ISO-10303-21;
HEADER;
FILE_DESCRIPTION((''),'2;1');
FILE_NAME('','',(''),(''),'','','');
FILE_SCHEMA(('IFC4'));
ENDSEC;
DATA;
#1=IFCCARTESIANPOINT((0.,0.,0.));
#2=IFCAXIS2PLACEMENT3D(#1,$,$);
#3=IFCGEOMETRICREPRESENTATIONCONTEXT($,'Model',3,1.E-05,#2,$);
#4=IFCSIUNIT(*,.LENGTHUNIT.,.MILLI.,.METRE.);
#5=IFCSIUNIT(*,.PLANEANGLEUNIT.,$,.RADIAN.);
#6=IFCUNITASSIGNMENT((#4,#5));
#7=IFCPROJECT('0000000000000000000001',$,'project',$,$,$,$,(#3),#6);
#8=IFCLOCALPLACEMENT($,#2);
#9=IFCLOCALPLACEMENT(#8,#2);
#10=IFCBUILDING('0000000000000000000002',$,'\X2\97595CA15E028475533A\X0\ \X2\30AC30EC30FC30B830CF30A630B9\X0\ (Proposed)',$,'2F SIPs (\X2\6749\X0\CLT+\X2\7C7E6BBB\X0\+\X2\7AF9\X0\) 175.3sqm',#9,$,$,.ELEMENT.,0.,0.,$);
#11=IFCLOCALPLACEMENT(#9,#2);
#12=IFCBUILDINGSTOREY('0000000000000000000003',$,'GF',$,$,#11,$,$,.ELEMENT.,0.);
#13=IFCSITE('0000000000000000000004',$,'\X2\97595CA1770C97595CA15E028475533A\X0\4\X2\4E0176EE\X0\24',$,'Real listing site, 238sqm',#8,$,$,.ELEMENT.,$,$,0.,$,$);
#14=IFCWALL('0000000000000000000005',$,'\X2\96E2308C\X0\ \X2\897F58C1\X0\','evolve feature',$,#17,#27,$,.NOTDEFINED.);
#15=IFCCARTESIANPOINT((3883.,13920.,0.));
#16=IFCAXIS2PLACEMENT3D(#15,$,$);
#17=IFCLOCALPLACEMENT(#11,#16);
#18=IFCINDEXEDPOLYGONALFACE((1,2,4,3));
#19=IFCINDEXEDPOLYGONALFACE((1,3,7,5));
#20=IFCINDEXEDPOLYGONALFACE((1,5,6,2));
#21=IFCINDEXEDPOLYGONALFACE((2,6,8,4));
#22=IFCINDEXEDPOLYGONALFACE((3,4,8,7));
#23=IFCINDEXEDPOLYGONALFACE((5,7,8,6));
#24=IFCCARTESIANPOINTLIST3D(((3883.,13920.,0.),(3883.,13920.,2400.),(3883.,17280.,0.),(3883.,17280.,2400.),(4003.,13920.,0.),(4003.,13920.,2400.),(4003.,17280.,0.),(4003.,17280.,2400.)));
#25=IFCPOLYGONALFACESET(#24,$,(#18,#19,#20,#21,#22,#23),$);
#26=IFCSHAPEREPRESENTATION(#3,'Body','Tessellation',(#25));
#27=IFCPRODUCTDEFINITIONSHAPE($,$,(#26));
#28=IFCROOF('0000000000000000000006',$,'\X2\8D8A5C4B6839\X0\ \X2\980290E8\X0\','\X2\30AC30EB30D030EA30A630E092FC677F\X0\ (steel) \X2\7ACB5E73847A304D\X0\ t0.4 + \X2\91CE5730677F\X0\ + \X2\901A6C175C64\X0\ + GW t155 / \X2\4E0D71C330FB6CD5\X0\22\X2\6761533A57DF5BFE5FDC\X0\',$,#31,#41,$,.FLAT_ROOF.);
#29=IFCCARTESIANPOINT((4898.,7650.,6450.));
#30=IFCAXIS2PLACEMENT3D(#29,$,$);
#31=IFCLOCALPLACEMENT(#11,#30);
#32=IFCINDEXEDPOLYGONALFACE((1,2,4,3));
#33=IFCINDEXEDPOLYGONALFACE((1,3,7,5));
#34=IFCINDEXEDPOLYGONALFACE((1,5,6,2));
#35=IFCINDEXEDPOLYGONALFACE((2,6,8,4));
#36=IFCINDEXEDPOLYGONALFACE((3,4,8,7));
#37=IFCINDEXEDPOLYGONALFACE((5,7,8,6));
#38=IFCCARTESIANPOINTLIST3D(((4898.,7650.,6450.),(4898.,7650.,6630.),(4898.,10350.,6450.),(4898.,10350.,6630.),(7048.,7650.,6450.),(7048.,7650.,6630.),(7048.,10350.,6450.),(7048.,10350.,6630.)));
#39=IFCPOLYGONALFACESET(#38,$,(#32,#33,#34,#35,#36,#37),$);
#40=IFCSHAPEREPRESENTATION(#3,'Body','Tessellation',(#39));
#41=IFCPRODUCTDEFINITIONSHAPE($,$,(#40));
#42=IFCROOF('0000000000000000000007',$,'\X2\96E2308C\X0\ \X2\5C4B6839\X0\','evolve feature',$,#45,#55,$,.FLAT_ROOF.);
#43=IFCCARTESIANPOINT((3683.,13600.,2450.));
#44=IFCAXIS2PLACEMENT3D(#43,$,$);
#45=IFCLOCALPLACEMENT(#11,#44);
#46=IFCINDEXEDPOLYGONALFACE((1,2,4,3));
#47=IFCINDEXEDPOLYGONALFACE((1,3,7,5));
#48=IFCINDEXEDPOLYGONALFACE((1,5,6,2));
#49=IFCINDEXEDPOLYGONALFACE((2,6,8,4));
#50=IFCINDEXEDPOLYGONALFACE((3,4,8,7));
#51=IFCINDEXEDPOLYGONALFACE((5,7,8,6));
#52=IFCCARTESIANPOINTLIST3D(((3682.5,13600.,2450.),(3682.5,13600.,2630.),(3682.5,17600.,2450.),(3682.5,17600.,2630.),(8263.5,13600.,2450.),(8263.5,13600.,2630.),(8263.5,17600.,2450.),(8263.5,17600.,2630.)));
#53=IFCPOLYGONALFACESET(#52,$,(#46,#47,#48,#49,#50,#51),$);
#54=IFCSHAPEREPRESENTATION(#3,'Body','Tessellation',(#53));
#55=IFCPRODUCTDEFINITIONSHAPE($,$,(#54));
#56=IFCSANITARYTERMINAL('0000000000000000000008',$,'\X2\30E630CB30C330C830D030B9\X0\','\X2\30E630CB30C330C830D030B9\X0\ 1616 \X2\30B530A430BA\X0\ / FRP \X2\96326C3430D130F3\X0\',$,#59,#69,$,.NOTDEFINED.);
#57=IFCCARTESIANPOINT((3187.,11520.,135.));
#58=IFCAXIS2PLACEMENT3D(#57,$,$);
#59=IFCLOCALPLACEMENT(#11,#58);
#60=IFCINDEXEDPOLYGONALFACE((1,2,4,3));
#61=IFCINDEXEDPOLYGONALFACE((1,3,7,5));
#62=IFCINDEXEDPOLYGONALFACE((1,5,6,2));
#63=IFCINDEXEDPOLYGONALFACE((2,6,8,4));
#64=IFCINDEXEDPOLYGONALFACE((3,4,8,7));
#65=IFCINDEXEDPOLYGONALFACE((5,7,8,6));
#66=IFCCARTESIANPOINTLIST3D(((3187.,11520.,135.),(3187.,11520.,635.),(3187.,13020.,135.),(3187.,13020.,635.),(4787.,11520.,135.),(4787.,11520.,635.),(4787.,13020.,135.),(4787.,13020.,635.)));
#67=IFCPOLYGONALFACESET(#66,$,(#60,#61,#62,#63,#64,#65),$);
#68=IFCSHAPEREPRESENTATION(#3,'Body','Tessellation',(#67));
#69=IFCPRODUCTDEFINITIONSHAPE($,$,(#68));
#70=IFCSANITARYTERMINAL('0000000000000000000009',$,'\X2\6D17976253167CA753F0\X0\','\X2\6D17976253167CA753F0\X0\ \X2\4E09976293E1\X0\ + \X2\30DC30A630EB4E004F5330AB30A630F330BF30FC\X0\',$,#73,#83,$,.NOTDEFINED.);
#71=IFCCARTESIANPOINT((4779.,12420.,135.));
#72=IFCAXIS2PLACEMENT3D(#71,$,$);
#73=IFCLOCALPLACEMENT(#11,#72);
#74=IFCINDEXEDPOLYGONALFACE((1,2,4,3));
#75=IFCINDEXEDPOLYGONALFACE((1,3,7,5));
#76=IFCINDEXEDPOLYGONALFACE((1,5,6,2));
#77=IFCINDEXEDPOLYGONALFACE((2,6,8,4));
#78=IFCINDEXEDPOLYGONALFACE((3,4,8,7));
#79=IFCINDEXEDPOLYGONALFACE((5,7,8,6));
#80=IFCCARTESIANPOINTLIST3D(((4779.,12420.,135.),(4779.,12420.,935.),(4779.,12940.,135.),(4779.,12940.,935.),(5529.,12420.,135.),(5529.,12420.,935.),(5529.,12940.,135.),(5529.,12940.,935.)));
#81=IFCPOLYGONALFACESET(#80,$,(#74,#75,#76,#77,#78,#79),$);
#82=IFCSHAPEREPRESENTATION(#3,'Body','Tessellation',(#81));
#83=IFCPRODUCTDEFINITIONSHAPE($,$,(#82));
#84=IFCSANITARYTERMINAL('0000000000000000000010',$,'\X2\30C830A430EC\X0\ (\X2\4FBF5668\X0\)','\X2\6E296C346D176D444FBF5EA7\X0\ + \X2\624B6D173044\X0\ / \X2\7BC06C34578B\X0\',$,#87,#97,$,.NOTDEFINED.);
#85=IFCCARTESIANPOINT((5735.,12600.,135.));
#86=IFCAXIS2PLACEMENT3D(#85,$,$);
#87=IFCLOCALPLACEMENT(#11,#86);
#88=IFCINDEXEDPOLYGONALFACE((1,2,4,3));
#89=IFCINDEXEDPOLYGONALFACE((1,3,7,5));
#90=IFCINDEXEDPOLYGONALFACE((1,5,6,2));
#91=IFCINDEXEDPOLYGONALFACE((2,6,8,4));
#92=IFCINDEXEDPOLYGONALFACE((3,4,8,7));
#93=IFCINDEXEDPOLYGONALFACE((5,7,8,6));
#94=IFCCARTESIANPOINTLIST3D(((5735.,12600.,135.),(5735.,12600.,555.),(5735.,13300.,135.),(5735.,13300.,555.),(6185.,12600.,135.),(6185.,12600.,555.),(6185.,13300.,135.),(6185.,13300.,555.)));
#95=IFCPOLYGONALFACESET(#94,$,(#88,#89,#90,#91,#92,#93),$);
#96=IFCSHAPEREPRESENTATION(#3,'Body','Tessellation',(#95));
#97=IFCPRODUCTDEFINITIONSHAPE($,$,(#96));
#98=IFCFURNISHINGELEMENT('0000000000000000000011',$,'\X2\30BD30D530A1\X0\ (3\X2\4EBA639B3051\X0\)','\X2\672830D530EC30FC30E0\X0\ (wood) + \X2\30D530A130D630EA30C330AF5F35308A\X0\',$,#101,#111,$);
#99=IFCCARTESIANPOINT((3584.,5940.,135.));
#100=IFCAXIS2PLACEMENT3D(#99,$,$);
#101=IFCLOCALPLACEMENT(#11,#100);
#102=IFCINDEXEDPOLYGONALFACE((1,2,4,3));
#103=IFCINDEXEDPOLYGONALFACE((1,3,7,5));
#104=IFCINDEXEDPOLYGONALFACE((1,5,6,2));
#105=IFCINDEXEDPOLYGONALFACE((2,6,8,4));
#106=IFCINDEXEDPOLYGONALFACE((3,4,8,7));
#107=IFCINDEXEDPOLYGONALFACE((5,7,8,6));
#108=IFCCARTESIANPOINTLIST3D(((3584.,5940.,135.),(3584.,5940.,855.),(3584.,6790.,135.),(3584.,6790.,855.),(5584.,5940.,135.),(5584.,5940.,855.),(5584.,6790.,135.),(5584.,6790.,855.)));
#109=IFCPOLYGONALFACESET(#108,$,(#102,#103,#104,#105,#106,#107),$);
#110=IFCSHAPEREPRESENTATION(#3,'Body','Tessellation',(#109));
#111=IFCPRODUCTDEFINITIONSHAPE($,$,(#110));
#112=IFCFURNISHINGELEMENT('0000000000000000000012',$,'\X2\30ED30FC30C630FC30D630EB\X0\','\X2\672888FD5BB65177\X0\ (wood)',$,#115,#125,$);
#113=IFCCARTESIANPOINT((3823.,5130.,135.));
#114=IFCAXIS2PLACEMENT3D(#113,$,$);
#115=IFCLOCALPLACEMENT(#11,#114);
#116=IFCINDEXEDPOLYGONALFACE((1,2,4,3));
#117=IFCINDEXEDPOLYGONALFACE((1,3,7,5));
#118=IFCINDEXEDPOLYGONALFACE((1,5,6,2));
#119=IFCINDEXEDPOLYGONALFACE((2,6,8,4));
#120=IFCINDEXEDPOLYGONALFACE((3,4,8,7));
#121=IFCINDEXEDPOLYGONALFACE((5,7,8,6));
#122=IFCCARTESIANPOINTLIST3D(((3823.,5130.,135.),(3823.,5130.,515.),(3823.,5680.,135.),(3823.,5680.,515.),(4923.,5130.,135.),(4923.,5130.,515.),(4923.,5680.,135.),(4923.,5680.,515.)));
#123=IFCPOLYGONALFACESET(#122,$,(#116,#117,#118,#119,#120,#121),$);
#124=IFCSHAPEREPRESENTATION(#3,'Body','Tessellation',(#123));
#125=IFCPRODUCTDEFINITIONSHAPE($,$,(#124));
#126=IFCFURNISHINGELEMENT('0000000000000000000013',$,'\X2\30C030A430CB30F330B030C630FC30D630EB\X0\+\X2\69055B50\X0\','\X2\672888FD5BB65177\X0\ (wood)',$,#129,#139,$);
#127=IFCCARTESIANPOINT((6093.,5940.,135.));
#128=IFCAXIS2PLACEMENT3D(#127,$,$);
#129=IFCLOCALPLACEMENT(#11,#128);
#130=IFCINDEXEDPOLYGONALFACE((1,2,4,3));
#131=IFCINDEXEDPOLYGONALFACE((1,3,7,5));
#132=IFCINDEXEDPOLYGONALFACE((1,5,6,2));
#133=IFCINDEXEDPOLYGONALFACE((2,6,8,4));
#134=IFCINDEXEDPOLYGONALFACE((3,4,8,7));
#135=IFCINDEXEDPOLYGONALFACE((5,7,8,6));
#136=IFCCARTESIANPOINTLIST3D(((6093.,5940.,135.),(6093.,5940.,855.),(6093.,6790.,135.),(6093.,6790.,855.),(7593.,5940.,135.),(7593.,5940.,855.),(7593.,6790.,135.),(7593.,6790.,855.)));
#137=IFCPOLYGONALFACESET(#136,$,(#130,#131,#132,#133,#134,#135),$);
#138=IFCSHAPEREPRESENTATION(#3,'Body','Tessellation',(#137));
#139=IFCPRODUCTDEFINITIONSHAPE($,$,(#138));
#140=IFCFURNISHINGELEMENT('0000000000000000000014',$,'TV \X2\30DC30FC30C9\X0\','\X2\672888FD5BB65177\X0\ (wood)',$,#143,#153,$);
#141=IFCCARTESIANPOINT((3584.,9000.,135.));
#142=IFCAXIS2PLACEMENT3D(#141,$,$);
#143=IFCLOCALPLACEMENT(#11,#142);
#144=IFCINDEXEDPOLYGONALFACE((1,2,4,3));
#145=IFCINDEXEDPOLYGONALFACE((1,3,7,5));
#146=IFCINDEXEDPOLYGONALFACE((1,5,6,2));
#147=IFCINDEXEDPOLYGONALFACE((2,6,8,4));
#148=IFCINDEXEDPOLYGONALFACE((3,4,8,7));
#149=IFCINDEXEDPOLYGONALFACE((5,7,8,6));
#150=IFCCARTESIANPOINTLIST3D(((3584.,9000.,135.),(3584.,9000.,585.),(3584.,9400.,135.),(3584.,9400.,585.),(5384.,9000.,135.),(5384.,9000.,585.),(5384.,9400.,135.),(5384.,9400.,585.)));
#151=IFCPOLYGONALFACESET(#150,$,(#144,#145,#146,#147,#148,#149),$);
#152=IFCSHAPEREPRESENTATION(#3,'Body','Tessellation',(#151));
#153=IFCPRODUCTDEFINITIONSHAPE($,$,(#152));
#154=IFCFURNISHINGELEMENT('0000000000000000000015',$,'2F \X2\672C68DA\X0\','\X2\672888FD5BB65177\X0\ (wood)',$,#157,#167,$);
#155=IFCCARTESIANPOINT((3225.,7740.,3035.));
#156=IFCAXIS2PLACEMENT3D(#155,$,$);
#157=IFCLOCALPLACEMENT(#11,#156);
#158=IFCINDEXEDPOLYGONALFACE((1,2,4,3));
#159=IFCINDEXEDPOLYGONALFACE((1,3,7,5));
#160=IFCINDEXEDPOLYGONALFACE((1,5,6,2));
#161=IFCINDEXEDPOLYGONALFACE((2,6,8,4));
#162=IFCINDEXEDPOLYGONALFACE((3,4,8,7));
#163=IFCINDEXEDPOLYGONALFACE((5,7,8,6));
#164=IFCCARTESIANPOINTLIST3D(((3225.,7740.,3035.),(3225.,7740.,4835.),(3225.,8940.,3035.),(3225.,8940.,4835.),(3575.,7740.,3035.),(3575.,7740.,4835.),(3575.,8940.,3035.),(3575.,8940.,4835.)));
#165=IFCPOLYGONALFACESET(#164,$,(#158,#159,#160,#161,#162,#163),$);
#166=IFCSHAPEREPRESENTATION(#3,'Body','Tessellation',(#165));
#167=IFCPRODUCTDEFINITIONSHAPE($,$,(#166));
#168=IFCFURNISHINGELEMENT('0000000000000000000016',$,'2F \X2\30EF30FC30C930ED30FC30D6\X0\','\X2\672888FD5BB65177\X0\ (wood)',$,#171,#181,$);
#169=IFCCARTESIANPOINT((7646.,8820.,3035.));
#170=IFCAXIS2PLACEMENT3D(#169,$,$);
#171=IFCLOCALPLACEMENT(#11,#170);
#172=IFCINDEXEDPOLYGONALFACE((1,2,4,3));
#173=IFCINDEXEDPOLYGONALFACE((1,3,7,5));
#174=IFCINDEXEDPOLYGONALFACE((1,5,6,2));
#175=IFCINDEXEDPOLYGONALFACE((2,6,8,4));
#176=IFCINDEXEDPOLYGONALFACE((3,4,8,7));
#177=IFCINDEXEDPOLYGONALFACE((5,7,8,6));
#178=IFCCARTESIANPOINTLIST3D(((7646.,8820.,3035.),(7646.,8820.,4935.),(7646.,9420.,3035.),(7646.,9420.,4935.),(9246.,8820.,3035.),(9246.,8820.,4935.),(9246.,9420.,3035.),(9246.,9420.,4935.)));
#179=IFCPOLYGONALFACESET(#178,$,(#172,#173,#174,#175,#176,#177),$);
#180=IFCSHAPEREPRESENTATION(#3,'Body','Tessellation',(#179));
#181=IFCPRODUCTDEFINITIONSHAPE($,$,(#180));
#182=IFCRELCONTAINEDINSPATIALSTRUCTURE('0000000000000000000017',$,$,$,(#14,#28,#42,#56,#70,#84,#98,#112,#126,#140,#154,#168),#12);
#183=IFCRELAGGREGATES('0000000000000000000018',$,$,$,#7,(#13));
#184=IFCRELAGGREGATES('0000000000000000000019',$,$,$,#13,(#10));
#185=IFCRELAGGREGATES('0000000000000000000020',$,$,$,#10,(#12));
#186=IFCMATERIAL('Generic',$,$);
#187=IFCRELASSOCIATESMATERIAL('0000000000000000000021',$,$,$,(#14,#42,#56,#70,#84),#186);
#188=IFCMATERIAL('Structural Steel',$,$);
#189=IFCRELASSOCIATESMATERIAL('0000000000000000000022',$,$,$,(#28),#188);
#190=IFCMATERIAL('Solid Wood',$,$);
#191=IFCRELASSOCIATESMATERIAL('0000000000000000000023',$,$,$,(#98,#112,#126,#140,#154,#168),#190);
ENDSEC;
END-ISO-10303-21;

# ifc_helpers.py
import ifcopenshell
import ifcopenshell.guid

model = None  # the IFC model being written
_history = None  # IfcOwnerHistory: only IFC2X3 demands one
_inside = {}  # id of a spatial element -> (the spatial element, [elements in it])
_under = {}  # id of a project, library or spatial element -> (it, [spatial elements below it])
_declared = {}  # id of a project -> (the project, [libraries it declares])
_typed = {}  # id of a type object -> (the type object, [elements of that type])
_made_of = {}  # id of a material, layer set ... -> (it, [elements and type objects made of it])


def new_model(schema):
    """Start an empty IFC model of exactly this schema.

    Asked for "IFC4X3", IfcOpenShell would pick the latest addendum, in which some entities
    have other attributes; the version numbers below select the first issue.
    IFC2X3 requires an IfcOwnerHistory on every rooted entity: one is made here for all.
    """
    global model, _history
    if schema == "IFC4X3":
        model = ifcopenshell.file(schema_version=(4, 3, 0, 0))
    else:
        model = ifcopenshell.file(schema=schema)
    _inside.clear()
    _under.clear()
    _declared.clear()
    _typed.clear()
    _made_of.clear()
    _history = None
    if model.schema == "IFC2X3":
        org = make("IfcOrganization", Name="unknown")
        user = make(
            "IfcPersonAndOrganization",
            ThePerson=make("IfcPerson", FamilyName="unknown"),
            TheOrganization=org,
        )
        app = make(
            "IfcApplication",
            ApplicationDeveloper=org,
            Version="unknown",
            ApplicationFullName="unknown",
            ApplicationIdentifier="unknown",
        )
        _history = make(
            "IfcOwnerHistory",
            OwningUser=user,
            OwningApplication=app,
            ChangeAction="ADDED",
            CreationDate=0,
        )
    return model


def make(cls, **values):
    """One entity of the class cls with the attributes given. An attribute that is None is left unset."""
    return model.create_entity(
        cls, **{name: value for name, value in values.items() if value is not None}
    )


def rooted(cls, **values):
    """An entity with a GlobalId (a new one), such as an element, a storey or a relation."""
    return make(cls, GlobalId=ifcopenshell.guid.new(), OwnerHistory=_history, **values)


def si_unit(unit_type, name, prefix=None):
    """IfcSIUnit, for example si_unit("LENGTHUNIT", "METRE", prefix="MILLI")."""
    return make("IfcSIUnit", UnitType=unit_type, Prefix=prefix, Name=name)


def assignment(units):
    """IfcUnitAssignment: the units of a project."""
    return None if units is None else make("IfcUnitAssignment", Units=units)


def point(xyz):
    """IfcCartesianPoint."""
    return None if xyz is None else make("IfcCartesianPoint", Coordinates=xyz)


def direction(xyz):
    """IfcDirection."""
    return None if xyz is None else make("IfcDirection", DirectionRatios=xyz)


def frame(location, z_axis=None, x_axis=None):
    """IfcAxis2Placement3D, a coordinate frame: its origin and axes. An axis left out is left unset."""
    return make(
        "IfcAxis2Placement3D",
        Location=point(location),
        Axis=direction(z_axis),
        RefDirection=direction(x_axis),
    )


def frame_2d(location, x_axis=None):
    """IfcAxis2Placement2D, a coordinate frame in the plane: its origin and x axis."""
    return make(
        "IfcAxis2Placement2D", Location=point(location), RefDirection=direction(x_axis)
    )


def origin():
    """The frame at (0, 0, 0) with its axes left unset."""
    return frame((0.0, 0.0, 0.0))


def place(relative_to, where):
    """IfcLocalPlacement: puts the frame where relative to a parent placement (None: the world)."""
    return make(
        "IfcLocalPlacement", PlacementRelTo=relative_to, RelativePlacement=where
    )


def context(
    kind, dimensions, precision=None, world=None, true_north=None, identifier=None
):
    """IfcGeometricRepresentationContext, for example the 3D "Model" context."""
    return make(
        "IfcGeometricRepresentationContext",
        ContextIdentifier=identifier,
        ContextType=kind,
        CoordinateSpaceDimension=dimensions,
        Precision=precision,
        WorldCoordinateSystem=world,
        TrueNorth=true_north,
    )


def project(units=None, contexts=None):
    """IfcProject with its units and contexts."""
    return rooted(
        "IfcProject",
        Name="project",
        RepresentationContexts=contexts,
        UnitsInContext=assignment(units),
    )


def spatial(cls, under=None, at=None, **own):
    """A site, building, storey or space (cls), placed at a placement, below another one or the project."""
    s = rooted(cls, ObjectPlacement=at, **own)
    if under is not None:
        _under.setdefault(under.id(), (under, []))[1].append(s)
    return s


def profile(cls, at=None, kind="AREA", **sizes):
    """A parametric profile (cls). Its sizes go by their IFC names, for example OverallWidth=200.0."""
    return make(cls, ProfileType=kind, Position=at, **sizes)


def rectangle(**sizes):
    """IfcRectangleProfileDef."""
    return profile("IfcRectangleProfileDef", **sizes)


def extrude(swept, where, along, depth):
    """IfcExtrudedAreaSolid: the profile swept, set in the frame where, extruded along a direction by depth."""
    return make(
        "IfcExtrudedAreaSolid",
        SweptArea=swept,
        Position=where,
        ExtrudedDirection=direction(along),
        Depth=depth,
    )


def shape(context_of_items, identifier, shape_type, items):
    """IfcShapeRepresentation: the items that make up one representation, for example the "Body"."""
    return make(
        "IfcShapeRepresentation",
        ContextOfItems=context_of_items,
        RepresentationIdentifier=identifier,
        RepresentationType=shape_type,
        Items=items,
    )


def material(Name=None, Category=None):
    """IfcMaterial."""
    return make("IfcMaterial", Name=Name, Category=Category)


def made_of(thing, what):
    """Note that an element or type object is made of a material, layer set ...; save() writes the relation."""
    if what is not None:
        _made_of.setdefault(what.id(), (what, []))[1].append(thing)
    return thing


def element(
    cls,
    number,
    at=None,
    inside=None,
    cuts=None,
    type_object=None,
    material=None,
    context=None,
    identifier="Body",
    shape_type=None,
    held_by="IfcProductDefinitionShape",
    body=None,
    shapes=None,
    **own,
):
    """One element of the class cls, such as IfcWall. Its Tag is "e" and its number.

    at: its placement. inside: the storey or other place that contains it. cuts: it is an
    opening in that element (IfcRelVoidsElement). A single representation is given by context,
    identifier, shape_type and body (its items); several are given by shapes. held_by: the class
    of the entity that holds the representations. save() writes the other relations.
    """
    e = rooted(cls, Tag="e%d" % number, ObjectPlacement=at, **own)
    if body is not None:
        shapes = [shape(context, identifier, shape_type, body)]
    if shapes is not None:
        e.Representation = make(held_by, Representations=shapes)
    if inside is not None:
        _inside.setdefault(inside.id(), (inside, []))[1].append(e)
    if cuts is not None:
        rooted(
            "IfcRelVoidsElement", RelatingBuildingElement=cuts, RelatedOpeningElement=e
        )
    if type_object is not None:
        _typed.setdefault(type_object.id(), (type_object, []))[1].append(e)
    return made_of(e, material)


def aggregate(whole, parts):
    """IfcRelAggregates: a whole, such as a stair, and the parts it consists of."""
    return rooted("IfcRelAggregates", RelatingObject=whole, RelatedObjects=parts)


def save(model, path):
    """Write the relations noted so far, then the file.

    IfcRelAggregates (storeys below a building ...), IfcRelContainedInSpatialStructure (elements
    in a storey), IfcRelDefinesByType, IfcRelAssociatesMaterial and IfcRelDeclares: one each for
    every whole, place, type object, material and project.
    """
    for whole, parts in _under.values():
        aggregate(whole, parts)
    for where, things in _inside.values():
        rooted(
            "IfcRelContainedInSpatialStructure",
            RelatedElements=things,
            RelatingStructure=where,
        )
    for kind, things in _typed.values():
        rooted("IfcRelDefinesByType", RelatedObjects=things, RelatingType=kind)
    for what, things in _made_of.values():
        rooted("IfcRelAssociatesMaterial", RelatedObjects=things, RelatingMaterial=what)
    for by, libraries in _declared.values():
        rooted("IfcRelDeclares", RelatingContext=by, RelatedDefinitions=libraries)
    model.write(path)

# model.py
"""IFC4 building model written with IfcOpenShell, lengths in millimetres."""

from ifc_helpers import new_model, si_unit, frame, frame_2d, origin, place, context, project, spatial, rectangle, extrude, material, element, save


model = new_model("IFC4")

# Units and contexts
model_context = context("Model", 3, precision=1e-05, world=origin())
ifc_project = project(units=[si_unit("LENGTHUNIT", "METRE", prefix="MILLI"), si_unit("PLANEANGLEUNIT", "RADIAN")], contexts=[model_context])

# Site, building, storey
site_placement = place(None, origin())
site = spatial("IfcSite", under=ifc_project, at=site_placement, Name="静岡県静岡市葵区4丁目24", ObjectType="Real listing site, 238sqm", CompositionType="ELEMENT", RefElevation=0.0)
building_placement = place(site_placement, origin())
building = spatial("IfcBuilding", under=site, at=building_placement, Name="静岡市葵区 ガレージハウス (Proposed)", ObjectType="2F SIPs (杉CLT+籾殻+竹) 175.3sqm", CompositionType="ELEMENT", ElevationOfRefHeight=0.0, ElevationOfTerrain=0.0)
storey_placement = place(building_placement, origin())
storey = spatial("IfcBuildingStorey", under=building, at=storey_placement, Name="GF", CompositionType="ELEMENT", Elevation=0.0)

# Shared definitions
ifc_material_1 = material(Name="Generic")

# Shared definitions
ifc_material_2 = material(Name="Solid Wood")

# Wall
wall_1_placement = place(storey_placement, frame((3883.0, 13920.0, 0.0)))
element("IfcWall", 1, at=wall_1_placement, inside=storey, material=ifc_material_1, Name="離れ 西壁", Description="evolve feature", PredefinedType="NOTDEFINED", context=model_context, shape_type="SweptSolid", body=[
    extrude(rectangle(XDim=120.0, YDim=3360.0, at=frame_2d((60.0, 1680.0))), frame((3883.0, 13920.0, 0.0)), (0.0, 0.0, 1.0), 2400.0),
])

# Roofs
ifc_material_3 = material(Name="Structural Steel")
roof_1_placement = place(storey_placement, frame((4898.0, 7650.0, 6450.0)))
element("IfcRoof", 2, at=roof_1_placement, inside=storey, material=ifc_material_3, Name="越屋根 頂部", Description="ガルバリウム鋼板 (steel) 立平葺き t0.4 + 野地板 + 通気層 + GW t155 / 不燃・法22条区域対応", PredefinedType="FLAT_ROOF", context=model_context, shape_type="SweptSolid", body=[
    extrude(rectangle(XDim=2150.0, YDim=2700.0, at=frame_2d((1075.0, 1350.0))), frame((4898.0, 7650.0, 6450.0)), (0.0, 0.0, 1.0), 180.0),
])
roof_2_placement = place(storey_placement, frame((3683.0, 13600.0, 2450.0)))
element("IfcRoof", 3, at=roof_2_placement, inside=storey, material=ifc_material_1, Name="離れ 屋根", Description="evolve feature", PredefinedType="FLAT_ROOF", context=model_context, shape_type="SweptSolid", body=[
    extrude(rectangle(XDim=4581.0, YDim=4000.0, at=frame_2d((2290.0, 2000.0))), frame((3683.0, 13600.0, 2450.0)), (0.0, 0.0, 1.0), 180.0),
])

# Sanitary terminals
sanitary_terminal_1_placement = place(storey_placement, frame((3187.0, 11520.0, 135.0)))
element("IfcSanitaryTerminal", 4, at=sanitary_terminal_1_placement, inside=storey, material=ifc_material_1, Name="ユニットバス", Description="ユニットバス 1616 サイズ / FRP 防水パン", PredefinedType="NOTDEFINED", context=model_context, shape_type="SweptSolid", body=[
    extrude(rectangle(XDim=1600.0, YDim=1500.0, at=frame_2d((800.0, 750.0))), frame((3187.0, 11520.0, 135.0)), (0.0, 0.0, 1.0), 500.0),
])
sanitary_terminal_2_placement = place(storey_placement, frame((4779.0, 12420.0, 135.0)))
element("IfcSanitaryTerminal", 5, at=sanitary_terminal_2_placement, inside=storey, material=ifc_material_1, Name="洗面化粧台", Description="洗面化粧台 三面鏡 + ボウル一体カウンター", PredefinedType="NOTDEFINED", context=model_context, shape_type="SweptSolid", body=[
    extrude(rectangle(XDim=750.0, YDim=520.0, at=frame_2d((375.0, 260.0))), frame((4779.0, 12420.0, 135.0)), (0.0, 0.0, 1.0), 800.0),
])
sanitary_terminal_3_placement = place(storey_placement, frame((5735.0, 12600.0, 135.0)))
element("IfcSanitaryTerminal", 6, at=sanitary_terminal_3_placement, inside=storey, material=ifc_material_1, Name="トイレ (便器)", Description="温水洗浄便座 + 手洗い / 節水型", PredefinedType="NOTDEFINED", context=model_context, shape_type="SweptSolid", body=[
    extrude(rectangle(XDim=450.0, YDim=700.0, at=frame_2d((225.0, 350.0))), frame((5735.0, 12600.0, 135.0)), (0.0, 0.0, 1.0), 420.0),
])

# Furnishing elements
furnishing_1_placement = place(storey_placement, frame((3584.0, 5940.0, 135.0)))
element("IfcFurnishingElement", 7, at=furnishing_1_placement, inside=storey, material=ifc_material_2, Name="ソファ (3人掛け)", Description="木フレーム (wood) + ファブリック張り", context=model_context, shape_type="SweptSolid", body=[
    extrude(rectangle(XDim=2000.0, YDim=850.0, at=frame_2d((1000.0, 425.0))), frame((3584.0, 5940.0, 135.0)), (0.0, 0.0, 1.0), 720.0),
])
furnishing_2_placement = place(storey_placement, frame((3823.0, 5130.0, 135.0)))
element("IfcFurnishingElement", 8, at=furnishing_2_placement, inside=storey, material=ifc_material_2, Name="ローテーブル", Description="木製家具 (wood)", context=model_context, shape_type="SweptSolid", body=[
    extrude(rectangle(XDim=1100.0, YDim=550.0, at=frame_2d((550.0, 275.0))), frame((3823.0, 5130.0, 135.0)), (0.0, 0.0, 1.0), 380.0),
])
furnishing_3_placement = place(storey_placement, frame((6093.0, 5940.0, 135.0)))
element("IfcFurnishingElement", 9, at=furnishing_3_placement, inside=storey, material=ifc_material_2, Name="ダイニングテーブル+椅子", Description="木製家具 (wood)", context=model_context, shape_type="SweptSolid", body=[
    extrude(rectangle(XDim=1500.0, YDim=850.0, at=frame_2d((750.0, 425.0))), frame((6093.0, 5940.0, 135.0)), (0.0, 0.0, 1.0), 720.0),
])
furnishing_4_placement = place(storey_placement, frame((3584.0, 9000.0, 135.0)))
element("IfcFurnishingElement", 10, at=furnishing_4_placement, inside=storey, material=ifc_material_2, Name="TV ボード", Description="木製家具 (wood)", context=model_context, shape_type="SweptSolid", body=[
    extrude(rectangle(XDim=1800.0, YDim=400.0, at=frame_2d((900.0, 200.0))), frame((3584.0, 9000.0, 135.0)), (0.0, 0.0, 1.0), 450.0),
])
furnishing_5_placement = place(storey_placement, frame((3225.0, 7740.0, 3035.0)))
element("IfcFurnishingElement", 11, at=furnishing_5_placement, inside=storey, material=ifc_material_2, Name="2F 本棚", Description="木製家具 (wood)", context=model_context, shape_type="SweptSolid", body=[
    extrude(rectangle(XDim=350.0, YDim=1200.0, at=frame_2d((175.0, 600.0))), frame((3225.0, 7740.0, 3035.0)), (0.0, 0.0, 1.0), 1800.0),
])
furnishing_6_placement = place(storey_placement, frame((7646.0, 8820.0, 3035.0)))
element("IfcFurnishingElement", 12, at=furnishing_6_placement, inside=storey, material=ifc_material_2, Name="2F ワードローブ", Description="木製家具 (wood)", context=model_context, shape_type="SweptSolid", body=[
    extrude(rectangle(XDim=1600.0, YDim=600.0, at=frame_2d((800.0, 300.0))), frame((7646.0, 8820.0, 3035.0)), (0.0, 0.0, 1.0), 1900.0),
])

save(model, "model.ifc")
